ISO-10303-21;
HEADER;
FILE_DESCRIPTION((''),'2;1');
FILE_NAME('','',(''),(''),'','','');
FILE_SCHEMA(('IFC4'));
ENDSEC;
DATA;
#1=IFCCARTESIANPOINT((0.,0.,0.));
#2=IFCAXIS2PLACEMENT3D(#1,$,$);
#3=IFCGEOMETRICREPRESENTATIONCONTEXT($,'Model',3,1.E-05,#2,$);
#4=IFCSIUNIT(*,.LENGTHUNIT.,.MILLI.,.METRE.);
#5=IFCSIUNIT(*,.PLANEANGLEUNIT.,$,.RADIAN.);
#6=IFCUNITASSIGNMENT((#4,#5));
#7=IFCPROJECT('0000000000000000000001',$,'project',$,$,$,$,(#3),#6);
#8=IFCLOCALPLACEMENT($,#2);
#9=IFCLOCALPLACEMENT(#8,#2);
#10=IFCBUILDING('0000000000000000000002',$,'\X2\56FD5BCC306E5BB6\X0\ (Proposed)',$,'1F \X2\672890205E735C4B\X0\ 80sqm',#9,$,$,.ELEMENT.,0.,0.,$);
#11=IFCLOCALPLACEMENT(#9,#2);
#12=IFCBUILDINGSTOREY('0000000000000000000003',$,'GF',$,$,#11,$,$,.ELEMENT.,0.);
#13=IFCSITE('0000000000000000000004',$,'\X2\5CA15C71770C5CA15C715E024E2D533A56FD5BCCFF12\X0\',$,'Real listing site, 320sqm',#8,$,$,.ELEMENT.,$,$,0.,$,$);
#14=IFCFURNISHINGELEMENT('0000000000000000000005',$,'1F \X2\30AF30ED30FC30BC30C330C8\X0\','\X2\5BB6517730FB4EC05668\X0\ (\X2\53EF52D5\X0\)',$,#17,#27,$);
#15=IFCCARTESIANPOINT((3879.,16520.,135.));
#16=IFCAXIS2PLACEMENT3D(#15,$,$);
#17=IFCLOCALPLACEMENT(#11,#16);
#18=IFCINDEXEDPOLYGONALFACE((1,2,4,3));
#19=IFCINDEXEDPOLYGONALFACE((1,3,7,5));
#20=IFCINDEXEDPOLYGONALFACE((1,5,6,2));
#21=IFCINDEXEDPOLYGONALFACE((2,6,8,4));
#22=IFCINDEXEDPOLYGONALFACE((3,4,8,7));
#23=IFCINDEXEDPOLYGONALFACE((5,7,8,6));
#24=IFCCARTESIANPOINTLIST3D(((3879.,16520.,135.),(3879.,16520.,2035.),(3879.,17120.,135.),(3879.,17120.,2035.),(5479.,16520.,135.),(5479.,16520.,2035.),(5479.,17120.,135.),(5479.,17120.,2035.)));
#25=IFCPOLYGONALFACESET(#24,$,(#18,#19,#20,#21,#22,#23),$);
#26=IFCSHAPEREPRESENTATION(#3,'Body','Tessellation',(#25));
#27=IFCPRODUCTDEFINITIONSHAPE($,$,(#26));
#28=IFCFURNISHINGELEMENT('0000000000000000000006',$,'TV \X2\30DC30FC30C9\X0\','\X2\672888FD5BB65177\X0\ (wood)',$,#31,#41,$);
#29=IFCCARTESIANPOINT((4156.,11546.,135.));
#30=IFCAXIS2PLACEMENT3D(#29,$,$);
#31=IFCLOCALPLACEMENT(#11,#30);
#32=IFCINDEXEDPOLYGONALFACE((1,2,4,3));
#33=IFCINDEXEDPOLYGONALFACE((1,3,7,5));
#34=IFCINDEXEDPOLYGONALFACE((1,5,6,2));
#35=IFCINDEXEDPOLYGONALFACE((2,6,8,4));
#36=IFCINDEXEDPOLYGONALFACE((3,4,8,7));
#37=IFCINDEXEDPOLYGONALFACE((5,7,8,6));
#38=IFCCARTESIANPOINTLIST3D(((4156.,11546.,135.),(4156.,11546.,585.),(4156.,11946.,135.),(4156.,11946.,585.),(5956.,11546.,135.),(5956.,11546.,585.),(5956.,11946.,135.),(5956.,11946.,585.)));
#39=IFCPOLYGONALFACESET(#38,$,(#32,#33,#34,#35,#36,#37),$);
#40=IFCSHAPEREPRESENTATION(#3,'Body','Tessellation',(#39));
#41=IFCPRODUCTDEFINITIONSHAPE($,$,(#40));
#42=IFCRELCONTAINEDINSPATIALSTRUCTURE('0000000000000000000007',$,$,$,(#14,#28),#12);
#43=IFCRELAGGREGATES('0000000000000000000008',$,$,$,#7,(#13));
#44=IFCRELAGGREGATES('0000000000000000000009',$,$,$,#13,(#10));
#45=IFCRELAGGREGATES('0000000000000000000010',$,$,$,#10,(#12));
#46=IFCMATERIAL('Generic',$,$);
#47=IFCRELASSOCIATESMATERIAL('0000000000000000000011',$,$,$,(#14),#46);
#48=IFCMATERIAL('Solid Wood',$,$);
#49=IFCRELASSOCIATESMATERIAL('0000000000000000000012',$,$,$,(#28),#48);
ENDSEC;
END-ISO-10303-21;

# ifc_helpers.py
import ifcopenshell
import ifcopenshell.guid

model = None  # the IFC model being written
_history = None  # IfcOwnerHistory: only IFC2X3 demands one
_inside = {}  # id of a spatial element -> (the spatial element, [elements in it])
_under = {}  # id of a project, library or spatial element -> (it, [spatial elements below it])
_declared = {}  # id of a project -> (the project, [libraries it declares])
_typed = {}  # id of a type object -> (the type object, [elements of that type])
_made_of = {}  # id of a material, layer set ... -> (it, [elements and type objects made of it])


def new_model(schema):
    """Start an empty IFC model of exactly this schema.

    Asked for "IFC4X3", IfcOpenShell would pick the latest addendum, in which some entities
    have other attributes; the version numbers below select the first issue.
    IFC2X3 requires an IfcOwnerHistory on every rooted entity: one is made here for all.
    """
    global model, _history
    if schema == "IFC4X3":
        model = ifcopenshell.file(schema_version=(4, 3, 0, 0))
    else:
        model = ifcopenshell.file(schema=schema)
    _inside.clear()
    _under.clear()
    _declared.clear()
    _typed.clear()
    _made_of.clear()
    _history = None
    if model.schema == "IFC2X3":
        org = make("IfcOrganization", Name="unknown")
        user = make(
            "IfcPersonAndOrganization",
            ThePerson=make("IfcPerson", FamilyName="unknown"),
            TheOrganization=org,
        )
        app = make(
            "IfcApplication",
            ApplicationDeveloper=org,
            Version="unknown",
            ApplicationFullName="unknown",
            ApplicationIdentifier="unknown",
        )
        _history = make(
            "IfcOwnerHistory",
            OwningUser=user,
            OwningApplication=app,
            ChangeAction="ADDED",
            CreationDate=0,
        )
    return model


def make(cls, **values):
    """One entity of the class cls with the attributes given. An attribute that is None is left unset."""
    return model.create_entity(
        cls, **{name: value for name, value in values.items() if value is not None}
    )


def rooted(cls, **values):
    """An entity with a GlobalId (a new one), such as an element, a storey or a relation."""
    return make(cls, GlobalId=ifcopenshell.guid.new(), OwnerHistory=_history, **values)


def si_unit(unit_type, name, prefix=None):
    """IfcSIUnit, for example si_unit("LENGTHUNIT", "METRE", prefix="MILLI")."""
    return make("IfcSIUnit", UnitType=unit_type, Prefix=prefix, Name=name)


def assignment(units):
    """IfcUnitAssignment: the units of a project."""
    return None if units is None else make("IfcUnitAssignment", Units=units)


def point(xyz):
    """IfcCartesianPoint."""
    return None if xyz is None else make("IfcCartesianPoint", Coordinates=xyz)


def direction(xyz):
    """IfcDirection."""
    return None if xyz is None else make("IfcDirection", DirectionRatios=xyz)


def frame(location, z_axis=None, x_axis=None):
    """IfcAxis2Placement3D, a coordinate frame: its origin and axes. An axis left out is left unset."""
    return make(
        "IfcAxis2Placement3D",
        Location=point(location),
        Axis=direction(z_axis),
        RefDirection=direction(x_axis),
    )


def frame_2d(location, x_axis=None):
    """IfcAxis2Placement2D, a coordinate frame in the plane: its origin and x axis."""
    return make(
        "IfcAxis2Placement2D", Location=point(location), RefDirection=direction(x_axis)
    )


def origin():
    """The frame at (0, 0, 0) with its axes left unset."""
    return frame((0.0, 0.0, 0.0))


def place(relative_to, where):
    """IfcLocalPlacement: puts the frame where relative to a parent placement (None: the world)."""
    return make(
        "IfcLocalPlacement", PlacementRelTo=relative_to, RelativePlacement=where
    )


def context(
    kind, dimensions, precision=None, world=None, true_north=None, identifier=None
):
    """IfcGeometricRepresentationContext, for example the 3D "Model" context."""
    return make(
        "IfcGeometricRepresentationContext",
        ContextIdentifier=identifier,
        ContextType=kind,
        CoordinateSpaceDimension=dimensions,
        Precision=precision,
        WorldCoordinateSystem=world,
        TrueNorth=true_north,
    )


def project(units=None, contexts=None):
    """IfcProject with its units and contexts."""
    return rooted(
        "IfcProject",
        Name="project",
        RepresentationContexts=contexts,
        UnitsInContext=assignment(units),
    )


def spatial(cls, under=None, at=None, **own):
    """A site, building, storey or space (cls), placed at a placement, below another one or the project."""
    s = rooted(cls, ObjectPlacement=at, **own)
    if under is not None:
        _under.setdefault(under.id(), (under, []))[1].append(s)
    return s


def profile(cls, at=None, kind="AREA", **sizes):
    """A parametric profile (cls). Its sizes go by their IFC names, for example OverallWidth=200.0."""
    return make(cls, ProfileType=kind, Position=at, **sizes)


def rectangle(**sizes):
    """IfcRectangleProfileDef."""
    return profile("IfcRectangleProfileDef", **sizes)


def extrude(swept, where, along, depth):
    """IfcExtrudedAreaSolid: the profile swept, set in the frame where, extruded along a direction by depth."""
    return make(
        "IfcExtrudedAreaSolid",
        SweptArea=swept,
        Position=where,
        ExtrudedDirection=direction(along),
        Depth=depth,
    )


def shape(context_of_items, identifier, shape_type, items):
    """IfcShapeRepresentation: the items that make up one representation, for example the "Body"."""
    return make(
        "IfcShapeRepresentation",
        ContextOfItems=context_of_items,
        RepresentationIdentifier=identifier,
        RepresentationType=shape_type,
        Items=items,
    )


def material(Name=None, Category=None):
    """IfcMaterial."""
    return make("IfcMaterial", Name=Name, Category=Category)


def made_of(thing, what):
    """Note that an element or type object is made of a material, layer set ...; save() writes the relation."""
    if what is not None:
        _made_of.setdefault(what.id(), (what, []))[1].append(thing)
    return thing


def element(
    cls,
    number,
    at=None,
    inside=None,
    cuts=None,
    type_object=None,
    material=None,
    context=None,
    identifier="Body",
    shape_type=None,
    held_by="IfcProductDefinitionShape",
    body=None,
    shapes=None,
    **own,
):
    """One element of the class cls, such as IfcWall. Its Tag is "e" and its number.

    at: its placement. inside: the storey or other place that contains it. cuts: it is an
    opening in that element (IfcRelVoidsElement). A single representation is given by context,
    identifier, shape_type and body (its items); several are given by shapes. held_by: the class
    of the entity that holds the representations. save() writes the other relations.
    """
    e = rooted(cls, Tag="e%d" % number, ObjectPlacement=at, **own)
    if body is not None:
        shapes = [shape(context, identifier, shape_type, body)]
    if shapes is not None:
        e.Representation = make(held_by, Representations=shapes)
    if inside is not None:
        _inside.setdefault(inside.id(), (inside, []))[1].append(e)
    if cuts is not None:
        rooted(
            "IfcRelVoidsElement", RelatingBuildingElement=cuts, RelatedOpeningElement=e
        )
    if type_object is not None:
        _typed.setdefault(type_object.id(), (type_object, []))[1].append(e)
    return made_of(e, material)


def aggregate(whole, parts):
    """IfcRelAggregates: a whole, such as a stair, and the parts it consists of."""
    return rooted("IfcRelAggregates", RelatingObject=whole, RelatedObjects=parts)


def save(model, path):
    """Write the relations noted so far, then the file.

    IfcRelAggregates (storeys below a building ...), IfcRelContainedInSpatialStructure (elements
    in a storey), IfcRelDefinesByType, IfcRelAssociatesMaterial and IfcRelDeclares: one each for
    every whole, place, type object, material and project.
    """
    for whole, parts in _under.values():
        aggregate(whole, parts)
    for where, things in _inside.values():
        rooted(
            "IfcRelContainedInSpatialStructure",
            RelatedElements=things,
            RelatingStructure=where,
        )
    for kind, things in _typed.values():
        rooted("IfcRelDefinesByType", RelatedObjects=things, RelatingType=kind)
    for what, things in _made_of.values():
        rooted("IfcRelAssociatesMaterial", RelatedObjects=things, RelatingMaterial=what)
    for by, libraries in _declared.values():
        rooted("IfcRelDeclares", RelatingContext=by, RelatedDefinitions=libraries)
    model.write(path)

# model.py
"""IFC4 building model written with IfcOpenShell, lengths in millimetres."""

from ifc_helpers import new_model, si_unit, frame, frame_2d, origin, place, context, project, spatial, rectangle, extrude, material, element, save


model = new_model("IFC4")

# Units and contexts
model_context = context("Model", 3, precision=1e-05, world=origin())
ifc_project = project(units=[si_unit("LENGTHUNIT", "METRE", prefix="MILLI"), si_unit("PLANEANGLEUNIT", "RADIAN")], contexts=[model_context])

# Site, building, storey
site_placement = place(None, origin())
site = spatial("IfcSite", under=ifc_project, at=site_placement, Name="岡山県岡山市中区国富２", ObjectType="Real listing site, 320sqm", CompositionType="ELEMENT", RefElevation=0.0)
building_placement = place(site_placement, origin())
building = spatial("IfcBuilding", under=site, at=building_placement, Name="国富の家 (Proposed)", ObjectType="1F 木造平屋 80sqm", CompositionType="ELEMENT", ElevationOfRefHeight=0.0, ElevationOfTerrain=0.0)
storey_placement = place(building_placement, origin())
storey = spatial("IfcBuildingStorey", under=building, at=storey_placement, Name="GF", CompositionType="ELEMENT", Elevation=0.0)

# Shared definitions
ifc_material_1 = material(Name="Solid Wood")

# Shared definitions
ifc_material_2 = material(Name="Generic")

# Furnishing elements
furnishing_1_placement = place(storey_placement, frame((3879.0, 16520.0, 135.0)))
element("IfcFurnishingElement", 1, at=furnishing_1_placement, inside=storey, material=ifc_material_2, Name="1F クローゼット", Description="家具・什器 (可動)", context=model_context, shape_type="SweptSolid", body=[
    extrude(rectangle(XDim=1600.0, YDim=600.0, at=frame_2d((800.0, 300.0))), frame((3879.0, 16520.0, 135.0)), (0.0, 0.0, 1.0), 1900.0),
])
furnishing_2_placement = place(storey_placement, frame((4156.0, 11546.0, 135.0)))
element("IfcFurnishingElement", 2, at=furnishing_2_placement, inside=storey, material=ifc_material_1, Name="TV ボード", Description="木製家具 (wood)", context=model_context, shape_type="SweptSolid", body=[
    extrude(rectangle(XDim=1800.0, YDim=400.0, at=frame_2d((900.0, 200.0))), frame((4156.0, 11546.0, 135.0)), (0.0, 0.0, 1.0), 450.0),
])

save(model, "model.ifc")
